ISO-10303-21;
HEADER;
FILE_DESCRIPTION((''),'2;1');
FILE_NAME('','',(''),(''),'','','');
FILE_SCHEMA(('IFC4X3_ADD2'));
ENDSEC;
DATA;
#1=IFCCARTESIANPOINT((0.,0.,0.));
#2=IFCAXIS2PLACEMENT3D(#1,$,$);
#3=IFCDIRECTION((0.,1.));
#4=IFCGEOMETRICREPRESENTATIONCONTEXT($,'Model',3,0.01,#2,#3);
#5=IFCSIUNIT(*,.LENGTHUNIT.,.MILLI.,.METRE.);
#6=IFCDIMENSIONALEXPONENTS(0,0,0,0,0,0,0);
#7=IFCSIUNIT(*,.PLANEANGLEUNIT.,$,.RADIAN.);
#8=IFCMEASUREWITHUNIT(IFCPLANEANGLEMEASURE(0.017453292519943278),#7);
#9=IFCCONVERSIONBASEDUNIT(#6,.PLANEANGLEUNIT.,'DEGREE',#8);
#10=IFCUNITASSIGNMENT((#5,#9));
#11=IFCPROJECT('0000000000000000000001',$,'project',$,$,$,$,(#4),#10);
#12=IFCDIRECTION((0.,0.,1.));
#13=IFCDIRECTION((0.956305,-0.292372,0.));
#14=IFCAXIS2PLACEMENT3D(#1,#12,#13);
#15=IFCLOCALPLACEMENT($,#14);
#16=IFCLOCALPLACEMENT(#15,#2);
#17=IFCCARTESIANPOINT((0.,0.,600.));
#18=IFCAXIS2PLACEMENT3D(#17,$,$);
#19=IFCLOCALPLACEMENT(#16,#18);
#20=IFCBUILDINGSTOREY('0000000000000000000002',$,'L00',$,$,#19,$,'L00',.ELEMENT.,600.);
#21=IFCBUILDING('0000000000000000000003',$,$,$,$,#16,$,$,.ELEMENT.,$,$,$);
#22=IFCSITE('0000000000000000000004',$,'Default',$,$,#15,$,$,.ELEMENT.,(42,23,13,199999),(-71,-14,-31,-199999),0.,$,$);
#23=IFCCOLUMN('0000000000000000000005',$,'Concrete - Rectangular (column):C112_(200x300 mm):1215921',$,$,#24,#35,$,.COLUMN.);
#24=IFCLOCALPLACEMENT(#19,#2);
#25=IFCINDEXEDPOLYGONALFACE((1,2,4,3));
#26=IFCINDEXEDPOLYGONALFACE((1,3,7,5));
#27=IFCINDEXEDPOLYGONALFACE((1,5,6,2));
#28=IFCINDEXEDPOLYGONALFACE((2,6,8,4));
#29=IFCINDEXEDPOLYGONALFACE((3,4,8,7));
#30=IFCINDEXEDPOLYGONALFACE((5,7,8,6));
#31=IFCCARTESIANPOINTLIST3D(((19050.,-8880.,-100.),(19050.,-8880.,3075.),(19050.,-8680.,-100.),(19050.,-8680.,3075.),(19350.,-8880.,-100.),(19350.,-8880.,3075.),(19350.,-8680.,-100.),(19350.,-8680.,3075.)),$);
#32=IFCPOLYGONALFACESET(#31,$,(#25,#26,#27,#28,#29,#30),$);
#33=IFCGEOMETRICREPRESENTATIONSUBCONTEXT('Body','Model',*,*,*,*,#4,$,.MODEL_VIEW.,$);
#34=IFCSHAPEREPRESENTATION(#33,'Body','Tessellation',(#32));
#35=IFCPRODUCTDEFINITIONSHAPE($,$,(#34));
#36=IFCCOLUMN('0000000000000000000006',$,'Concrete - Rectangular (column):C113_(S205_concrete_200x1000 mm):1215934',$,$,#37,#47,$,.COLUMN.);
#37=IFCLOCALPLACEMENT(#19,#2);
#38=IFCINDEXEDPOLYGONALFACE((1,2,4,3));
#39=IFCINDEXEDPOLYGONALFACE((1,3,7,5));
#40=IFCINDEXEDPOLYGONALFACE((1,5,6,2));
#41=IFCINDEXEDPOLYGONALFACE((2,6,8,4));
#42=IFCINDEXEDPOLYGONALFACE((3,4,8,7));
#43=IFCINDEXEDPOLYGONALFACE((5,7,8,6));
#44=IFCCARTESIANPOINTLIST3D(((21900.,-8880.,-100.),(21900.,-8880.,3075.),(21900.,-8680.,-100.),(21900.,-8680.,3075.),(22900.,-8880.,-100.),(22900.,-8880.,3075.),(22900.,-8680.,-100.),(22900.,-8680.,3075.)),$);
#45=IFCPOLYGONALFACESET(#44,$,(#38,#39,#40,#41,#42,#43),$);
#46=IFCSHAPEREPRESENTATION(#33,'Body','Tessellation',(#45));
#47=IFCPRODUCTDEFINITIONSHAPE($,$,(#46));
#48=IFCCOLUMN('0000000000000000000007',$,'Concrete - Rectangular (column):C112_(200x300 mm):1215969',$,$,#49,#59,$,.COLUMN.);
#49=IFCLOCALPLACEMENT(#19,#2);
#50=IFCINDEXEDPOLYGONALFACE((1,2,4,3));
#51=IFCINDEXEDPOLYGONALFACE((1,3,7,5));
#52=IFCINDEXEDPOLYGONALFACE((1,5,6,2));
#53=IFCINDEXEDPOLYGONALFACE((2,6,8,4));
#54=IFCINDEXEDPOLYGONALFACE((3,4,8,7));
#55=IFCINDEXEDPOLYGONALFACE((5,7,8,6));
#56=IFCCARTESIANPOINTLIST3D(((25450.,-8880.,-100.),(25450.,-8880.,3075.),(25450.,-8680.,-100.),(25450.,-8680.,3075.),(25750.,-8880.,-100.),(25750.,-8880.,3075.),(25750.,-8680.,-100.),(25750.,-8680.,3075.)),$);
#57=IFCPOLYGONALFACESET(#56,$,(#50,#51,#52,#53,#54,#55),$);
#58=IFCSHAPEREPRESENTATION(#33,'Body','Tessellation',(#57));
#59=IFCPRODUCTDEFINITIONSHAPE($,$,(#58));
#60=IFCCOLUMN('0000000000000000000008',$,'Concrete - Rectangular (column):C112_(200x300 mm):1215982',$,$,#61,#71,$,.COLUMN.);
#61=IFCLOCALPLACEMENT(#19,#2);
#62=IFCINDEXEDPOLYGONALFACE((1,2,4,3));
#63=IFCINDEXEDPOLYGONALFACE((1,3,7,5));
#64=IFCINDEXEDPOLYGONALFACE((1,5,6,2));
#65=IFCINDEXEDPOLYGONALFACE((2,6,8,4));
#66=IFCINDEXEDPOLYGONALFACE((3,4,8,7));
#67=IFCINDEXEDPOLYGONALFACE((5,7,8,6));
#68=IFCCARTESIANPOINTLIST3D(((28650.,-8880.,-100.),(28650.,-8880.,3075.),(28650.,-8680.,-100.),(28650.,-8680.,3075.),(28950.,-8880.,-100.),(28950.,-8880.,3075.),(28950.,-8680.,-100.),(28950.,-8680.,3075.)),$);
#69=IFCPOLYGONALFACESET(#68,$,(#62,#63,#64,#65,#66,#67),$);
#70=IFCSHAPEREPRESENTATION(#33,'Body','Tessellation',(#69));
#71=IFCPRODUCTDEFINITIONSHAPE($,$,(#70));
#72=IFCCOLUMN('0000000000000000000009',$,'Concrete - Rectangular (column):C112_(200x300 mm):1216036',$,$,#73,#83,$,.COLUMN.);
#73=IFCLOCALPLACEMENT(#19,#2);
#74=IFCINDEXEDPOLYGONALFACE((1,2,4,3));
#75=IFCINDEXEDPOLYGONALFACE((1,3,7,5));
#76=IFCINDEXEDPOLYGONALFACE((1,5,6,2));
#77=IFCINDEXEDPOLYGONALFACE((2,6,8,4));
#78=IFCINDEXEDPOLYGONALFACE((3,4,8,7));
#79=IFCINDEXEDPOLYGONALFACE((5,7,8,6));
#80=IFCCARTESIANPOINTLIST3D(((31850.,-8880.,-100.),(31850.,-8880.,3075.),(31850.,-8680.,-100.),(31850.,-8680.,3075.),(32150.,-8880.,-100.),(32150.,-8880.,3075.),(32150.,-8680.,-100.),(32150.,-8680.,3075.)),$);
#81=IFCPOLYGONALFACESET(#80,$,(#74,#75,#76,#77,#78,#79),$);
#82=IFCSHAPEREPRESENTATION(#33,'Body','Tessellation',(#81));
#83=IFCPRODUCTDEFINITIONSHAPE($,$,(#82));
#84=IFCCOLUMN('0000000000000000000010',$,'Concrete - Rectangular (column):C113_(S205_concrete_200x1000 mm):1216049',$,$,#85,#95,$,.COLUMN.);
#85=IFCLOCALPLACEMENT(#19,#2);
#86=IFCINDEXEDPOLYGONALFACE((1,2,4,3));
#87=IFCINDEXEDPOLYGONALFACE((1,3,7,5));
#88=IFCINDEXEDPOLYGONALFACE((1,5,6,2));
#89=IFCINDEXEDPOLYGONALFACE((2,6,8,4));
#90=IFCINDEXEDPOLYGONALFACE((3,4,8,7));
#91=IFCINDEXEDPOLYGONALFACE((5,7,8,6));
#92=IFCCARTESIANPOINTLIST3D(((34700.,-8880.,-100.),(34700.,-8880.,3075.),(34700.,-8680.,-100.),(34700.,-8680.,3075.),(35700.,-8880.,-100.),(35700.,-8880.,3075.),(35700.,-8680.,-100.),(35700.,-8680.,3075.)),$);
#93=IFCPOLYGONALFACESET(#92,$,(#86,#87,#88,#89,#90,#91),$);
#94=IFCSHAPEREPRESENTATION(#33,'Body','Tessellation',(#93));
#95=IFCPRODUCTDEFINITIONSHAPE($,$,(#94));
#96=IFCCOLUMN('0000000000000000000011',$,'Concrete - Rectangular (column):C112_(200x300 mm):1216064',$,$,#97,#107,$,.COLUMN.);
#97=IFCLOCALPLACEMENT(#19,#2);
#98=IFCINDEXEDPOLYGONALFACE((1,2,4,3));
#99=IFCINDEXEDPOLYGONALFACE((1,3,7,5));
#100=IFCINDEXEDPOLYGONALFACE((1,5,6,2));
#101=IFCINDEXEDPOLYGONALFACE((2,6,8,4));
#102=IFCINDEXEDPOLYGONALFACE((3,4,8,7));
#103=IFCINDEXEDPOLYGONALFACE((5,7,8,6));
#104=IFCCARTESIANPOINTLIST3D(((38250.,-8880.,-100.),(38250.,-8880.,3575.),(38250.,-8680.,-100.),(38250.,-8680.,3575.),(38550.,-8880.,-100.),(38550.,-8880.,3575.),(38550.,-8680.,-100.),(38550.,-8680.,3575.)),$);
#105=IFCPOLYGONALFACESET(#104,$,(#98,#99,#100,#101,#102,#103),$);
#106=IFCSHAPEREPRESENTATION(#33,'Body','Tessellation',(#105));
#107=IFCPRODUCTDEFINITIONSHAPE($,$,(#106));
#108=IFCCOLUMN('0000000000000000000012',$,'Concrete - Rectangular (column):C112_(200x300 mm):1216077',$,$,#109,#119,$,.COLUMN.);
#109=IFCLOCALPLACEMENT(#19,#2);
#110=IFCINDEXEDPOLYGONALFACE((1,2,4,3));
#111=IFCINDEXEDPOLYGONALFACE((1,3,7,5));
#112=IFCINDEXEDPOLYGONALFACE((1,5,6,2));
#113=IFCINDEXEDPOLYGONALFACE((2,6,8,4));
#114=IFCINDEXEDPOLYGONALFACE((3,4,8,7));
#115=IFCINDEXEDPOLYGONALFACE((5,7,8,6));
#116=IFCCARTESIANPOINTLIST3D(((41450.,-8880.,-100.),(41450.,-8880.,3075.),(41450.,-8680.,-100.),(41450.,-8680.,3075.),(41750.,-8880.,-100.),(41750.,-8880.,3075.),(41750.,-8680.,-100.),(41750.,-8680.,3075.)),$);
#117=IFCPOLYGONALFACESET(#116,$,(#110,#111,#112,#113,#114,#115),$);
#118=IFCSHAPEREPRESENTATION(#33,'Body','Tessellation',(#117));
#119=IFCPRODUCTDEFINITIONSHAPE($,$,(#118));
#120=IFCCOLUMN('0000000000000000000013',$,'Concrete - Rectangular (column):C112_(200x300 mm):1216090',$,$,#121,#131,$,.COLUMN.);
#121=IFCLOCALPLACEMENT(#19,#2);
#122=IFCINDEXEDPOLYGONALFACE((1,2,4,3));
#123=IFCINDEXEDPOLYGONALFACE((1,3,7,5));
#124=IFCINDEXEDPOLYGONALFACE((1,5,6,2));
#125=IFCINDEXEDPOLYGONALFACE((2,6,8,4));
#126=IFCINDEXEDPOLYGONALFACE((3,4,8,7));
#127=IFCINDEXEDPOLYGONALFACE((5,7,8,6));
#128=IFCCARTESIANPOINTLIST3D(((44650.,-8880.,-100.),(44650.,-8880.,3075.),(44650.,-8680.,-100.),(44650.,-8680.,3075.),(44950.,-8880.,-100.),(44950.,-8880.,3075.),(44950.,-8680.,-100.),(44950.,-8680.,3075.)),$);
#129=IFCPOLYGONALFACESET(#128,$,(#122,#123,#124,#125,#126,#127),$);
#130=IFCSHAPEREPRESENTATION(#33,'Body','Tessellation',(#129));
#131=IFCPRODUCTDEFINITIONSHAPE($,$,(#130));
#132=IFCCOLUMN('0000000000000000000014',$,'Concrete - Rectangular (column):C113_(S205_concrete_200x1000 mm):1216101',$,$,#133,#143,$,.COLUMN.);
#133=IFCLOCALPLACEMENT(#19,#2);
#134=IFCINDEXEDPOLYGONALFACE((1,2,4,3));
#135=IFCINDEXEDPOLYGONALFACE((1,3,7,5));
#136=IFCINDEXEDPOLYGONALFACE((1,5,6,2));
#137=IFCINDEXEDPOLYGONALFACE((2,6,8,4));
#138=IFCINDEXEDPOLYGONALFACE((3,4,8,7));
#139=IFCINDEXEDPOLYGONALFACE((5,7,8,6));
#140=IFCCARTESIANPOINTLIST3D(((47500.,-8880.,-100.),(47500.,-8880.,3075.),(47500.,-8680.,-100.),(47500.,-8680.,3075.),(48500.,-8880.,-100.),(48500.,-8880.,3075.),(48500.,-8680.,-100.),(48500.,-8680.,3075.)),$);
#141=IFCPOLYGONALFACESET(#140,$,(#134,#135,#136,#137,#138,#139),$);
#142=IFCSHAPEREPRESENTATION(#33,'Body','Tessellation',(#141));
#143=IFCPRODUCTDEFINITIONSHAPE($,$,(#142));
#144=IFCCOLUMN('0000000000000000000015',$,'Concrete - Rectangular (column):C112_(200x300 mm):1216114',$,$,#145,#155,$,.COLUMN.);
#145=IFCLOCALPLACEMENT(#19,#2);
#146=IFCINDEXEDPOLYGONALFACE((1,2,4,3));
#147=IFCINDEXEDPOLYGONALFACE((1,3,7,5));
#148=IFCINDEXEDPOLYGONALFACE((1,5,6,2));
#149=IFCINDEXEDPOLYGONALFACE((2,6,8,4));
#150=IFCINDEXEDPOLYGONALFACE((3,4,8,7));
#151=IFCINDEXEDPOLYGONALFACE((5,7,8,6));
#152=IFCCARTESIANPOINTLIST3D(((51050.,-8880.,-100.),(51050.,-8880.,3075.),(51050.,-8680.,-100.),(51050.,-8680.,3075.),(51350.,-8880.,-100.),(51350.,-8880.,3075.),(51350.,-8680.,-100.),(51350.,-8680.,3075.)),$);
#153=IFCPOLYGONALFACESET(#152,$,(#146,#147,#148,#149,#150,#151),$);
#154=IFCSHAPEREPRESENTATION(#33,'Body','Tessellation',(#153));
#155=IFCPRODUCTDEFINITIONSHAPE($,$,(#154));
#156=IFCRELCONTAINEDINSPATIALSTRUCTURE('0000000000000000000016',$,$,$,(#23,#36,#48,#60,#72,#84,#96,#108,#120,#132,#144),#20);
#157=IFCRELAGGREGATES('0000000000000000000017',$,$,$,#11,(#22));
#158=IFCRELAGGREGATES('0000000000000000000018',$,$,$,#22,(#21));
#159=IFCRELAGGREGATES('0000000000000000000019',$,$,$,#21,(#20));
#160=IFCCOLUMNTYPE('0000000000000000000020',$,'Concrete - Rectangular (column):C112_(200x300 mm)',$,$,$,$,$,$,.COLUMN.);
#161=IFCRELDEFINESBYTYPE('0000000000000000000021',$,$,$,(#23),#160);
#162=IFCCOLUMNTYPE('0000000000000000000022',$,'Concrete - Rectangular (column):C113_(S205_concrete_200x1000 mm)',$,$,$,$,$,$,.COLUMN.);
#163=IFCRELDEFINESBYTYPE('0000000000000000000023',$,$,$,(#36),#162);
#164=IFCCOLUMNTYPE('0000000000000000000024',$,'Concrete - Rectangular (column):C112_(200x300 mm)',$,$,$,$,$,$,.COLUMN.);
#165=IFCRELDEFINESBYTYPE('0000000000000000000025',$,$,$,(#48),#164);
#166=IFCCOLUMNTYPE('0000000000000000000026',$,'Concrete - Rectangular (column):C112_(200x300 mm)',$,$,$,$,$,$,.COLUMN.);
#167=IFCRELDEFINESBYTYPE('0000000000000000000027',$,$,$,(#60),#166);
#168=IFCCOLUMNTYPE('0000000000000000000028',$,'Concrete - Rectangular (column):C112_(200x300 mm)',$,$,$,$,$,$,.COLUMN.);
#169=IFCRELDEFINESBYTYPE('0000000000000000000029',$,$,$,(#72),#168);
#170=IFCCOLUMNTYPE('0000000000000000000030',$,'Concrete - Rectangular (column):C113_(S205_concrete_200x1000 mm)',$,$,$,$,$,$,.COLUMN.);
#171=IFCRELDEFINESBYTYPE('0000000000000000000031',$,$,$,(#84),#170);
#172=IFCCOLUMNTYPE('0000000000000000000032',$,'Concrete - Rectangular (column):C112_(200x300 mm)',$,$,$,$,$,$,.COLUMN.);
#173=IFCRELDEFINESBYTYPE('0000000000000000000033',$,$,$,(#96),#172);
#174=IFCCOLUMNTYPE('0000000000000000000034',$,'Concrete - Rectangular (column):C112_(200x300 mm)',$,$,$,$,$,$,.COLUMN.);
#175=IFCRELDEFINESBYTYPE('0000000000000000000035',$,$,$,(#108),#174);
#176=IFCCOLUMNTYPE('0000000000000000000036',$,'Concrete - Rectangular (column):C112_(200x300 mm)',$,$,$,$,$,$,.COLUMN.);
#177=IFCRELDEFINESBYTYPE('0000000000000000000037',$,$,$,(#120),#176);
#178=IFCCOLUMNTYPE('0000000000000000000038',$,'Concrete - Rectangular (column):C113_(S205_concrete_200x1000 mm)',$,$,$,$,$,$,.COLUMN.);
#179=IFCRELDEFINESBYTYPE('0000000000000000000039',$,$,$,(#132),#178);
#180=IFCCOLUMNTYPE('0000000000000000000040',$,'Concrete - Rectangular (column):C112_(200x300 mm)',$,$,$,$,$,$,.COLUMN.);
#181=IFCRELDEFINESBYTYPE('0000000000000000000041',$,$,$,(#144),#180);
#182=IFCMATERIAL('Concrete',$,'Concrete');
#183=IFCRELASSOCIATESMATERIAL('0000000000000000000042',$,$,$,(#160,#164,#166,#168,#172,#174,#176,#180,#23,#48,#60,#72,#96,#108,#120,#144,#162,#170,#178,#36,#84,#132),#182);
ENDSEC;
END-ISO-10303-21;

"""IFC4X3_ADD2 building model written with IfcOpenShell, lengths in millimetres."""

from ifc_helpers import new_model, entity, si_unit, converted_unit, direction, frame, frame_2d, origin, place, context, subcontext, project, spatial, rectangle, extrude, source, transform, mapped, material, material_profile, profile_set, profile_usage, type_object, type_shapes, element, save


model = new_model("IFC4X3_ADD2")

# Units and contexts
model_context = context("Model", 3, precision=0.01, world=origin(), true_north=direction((0.0, 1.0)))
body_context = subcontext(model_context, "Body", "Model", "MODEL_VIEW")
ifc_project = project(units=[si_unit("LENGTHUNIT", "METRE", prefix="MILLI"), converted_unit("PLANEANGLEUNIT", "DEGREE", entity("IfcPlaneAngleMeasure", 0.017453292519943278), si_unit("PLANEANGLEUNIT", "RADIAN"), dimensions=[0, 0, 0, 0, 0, 0, 0])], contexts=[model_context])

# Site, building, storey
site_placement = place(None, frame((0.0, 0.0, 0.0), z_axis=(0.0, 0.0, 1.0), x_axis=(0.956305, -0.292372, 0.0)))
site = spatial("IfcSite", under=ifc_project, at=site_placement, Name="Default", CompositionType="ELEMENT", RefLatitude=(42, 23, 13, 199999), RefLongitude=(-71, -14, -31, -199999), RefElevation=0.0)
building_placement = place(site_placement, origin())
building = spatial("IfcBuilding", under=site, at=building_placement, CompositionType="ELEMENT")
storey_placement = place(building_placement, frame((0.0, 0.0, 600.0)))
storey = spatial("IfcBuildingStorey", under=building, at=storey_placement, Name="L00", LongName="L00", CompositionType="ELEMENT", Elevation=600.0)

# Columns
ifc_material = material(Name="Concrete", Category="Concrete")
ifc_material_profile_1 = material_profile(ifc_material, rectangle(XDim=200.0, YDim=300.0, at=frame_2d((0.0, 0.0), x_axis=(1.0, 0.0))), Name="C112_(200x300 mm)")
ifc_profile_set_1 = profile_set([ifc_material_profile_1], Name="C112_(200x300 mm)")
ifc_profile_usage_1 = profile_usage(ifc_profile_set_1)
column_type_1 = type_object("IfcColumnType", Name="Concrete - Rectangular (column):C112_(200x300 mm)", PredefinedType="COLUMN", material=ifc_profile_set_1)
shared_shape_1 = source(origin(), body_context, "Body", "SweptSolid", [
    extrude(rectangle(XDim=200.0, YDim=300.0, at=frame_2d((0.0, 0.0), x_axis=(1.0, 0.0))), frame((19200.0, -8780.0, 500.0), z_axis=(0.0, 0.0, 1.0), x_axis=(0.0, 1.0, 0.0)), (0.0, 0.0, 1.0), 3175.0),
])
type_shapes(column_type_1, [shared_shape_1])
column_1_placement = place(storey_placement, frame((0.0, 0.0, -600.0)))
element("IfcColumn", 1, at=column_1_placement, inside=storey, type_object=column_type_1, material=ifc_profile_usage_1, Name="Concrete - Rectangular (column):C112_(200x300 mm):1215921", PredefinedType="COLUMN", context=body_context, shape_type="MappedRepresentation", body=[
    mapped(shared_shape_1, transform((0.0, 0.0, 0.0), scale=1.0)),
])
ifc_material_profile_2 = material_profile(ifc_material, rectangle(XDim=200.0, YDim=1000.0, at=frame_2d((0.0, 0.0), x_axis=(1.0, 0.0))), Name="C113_(S205_concrete_200x1000 mm)")
ifc_profile_set_2 = profile_set([ifc_material_profile_2], Name="C113_(S205_concrete_200x1000 mm)")
ifc_profile_usage_2 = profile_usage(ifc_profile_set_2)
column_type_2 = type_object("IfcColumnType", Name="Concrete - Rectangular (column):C113_(S205_concrete_200x1000 mm)", PredefinedType="COLUMN", material=ifc_profile_set_2)
shared_shape_2 = source(origin(), body_context, "Body", "SweptSolid", [
    extrude(rectangle(XDim=200.0, YDim=1000.0, at=frame_2d((0.0, 0.0), x_axis=(1.0, 0.0))), frame((22400.0, -8780.0, 500.0), z_axis=(0.0, 0.0, 1.0), x_axis=(0.0, 1.0, 0.0)), (0.0, 0.0, 1.0), 3175.0),
])
type_shapes(column_type_2, [shared_shape_2])
column_2_placement = place(storey_placement, frame((0.0, 0.0, -600.0)))
element("IfcColumn", 2, at=column_2_placement, inside=storey, type_object=column_type_2, material=ifc_profile_usage_2, Name="Concrete - Rectangular (column):C113_(S205_concrete_200x1000 mm):1215934", PredefinedType="COLUMN", context=body_context, shape_type="MappedRepresentation", body=[
    mapped(shared_shape_2, transform((0.0, 0.0, 0.0), scale=1.0)),
])
column_type_3 = type_object("IfcColumnType", Name="Concrete - Rectangular (column):C112_(200x300 mm)", PredefinedType="COLUMN", material=ifc_profile_set_1)
shared_shape_3 = source(origin(), body_context, "Body", "SweptSolid", [
    extrude(rectangle(XDim=200.0, YDim=300.0, at=frame_2d((0.0, 0.0), x_axis=(1.0, 0.0))), frame((25600.0, -8780.0, 500.0), z_axis=(0.0, 0.0, 1.0), x_axis=(0.0, 1.0, 0.0)), (0.0, 0.0, 1.0), 3175.0),
])
type_shapes(column_type_3, [shared_shape_3])
column_3_placement = place(storey_placement, frame((0.0, 0.0, -600.0)))
element("IfcColumn", 3, at=column_3_placement, inside=storey, type_object=column_type_3, material=ifc_profile_usage_1, Name="Concrete - Rectangular (column):C112_(200x300 mm):1215969", PredefinedType="COLUMN", context=body_context, shape_type="MappedRepresentation", body=[
    mapped(shared_shape_3, transform((0.0, 0.0, 0.0), scale=1.0)),
])
column_type_4 = type_object("IfcColumnType", Name="Concrete - Rectangular (column):C112_(200x300 mm)", PredefinedType="COLUMN", material=ifc_profile_set_1)
shared_shape_4 = source(origin(), body_context, "Body", "SweptSolid", [
    extrude(rectangle(XDim=200.0, YDim=300.0, at=frame_2d((0.0, 0.0), x_axis=(1.0, 0.0))), frame((28800.0, -8780.0, 500.0), z_axis=(0.0, 0.0, 1.0), x_axis=(0.0, 1.0, 0.0)), (0.0, 0.0, 1.0), 3175.0),
])
type_shapes(column_type_4, [shared_shape_4])
column_4_placement = place(storey_placement, frame((0.0, 0.0, -600.0)))
element("IfcColumn", 4, at=column_4_placement, inside=storey, type_object=column_type_4, material=ifc_profile_usage_1, Name="Concrete - Rectangular (column):C112_(200x300 mm):1215982", PredefinedType="COLUMN", context=body_context, shape_type="MappedRepresentation", body=[
    mapped(shared_shape_4, transform((0.0, 0.0, 0.0), scale=1.0)),
])
column_type_5 = type_object("IfcColumnType", Name="Concrete - Rectangular (column):C112_(200x300 mm)", PredefinedType="COLUMN", material=ifc_profile_set_1)
shared_shape_5 = source(origin(), body_context, "Body", "SweptSolid", [
    extrude(rectangle(XDim=200.0, YDim=300.0, at=frame_2d((0.0, 0.0), x_axis=(1.0, 0.0))), frame((32000.0, -8780.0, 500.0), z_axis=(0.0, 0.0, 1.0), x_axis=(0.0, 1.0, 0.0)), (0.0, 0.0, 1.0), 3175.0),
])
type_shapes(column_type_5, [shared_shape_5])
column_5_placement = place(storey_placement, frame((0.0, 0.0, -600.0)))
element("IfcColumn", 5, at=column_5_placement, inside=storey, type_object=column_type_5, material=ifc_profile_usage_1, Name="Concrete - Rectangular (column):C112_(200x300 mm):1216036", PredefinedType="COLUMN", context=body_context, shape_type="MappedRepresentation", body=[
    mapped(shared_shape_5, transform((0.0, 0.0, 0.0), scale=1.0)),
])
column_type_6 = type_object("IfcColumnType", Name="Concrete - Rectangular (column):C113_(S205_concrete_200x1000 mm)", PredefinedType="COLUMN", material=ifc_profile_set_2)
shared_shape_6 = source(origin(), body_context, "Body", "SweptSolid", [
    extrude(rectangle(XDim=200.0, YDim=1000.0, at=frame_2d((0.0, 0.0), x_axis=(1.0, 0.0))), frame((35200.0, -8780.0, 500.0), z_axis=(0.0, 0.0, 1.0), x_axis=(0.0, 1.0, 0.0)), (0.0, 0.0, 1.0), 3175.0),
])
type_shapes(column_type_6, [shared_shape_6])
column_6_placement = place(storey_placement, frame((0.0, 0.0, -600.0)))
element("IfcColumn", 6, at=column_6_placement, inside=storey, type_object=column_type_6, material=ifc_profile_usage_2, Name="Concrete - Rectangular (column):C113_(S205_concrete_200x1000 mm):1216049", PredefinedType="COLUMN", context=body_context, shape_type="MappedRepresentation", body=[
    mapped(shared_shape_6, transform((0.0, 0.0, 0.0), scale=1.0)),
])
column_type_7 = type_object("IfcColumnType", Name="Concrete - Rectangular (column):C112_(200x300 mm)", PredefinedType="COLUMN", material=ifc_profile_set_1)
shared_shape_7 = source(origin(), body_context, "Body", "SweptSolid", [
    extrude(rectangle(XDim=200.0, YDim=300.0, at=frame_2d((0.0, 0.0), x_axis=(1.0, 0.0))), frame((38400.0, -8780.0, 500.0), z_axis=(0.0, 0.0, 1.0), x_axis=(0.0, 1.0, 0.0)), (0.0, 0.0, 1.0), 3675.0),
])
type_shapes(column_type_7, [shared_shape_7])
column_7_placement = place(storey_placement, frame((0.0, 0.0, -600.0)))
element("IfcColumn", 7, at=column_7_placement, inside=storey, type_object=column_type_7, material=ifc_profile_usage_1, Name="Concrete - Rectangular (column):C112_(200x300 mm):1216064", PredefinedType="COLUMN", context=body_context, shape_type="MappedRepresentation", body=[
    mapped(shared_shape_7, transform((0.0, 0.0, 0.0), scale=1.0)),
])
column_type_8 = type_object("IfcColumnType", Name="Concrete - Rectangular (column):C112_(200x300 mm)", PredefinedType="COLUMN", material=ifc_profile_set_1)
shared_shape_8 = source(origin(), body_context, "Body", "SweptSolid", [
    extrude(rectangle(XDim=200.0, YDim=300.0, at=frame_2d((0.0, 0.0), x_axis=(1.0, 0.0))), frame((41600.0, -8780.0, 500.0), z_axis=(0.0, 0.0, 1.0), x_axis=(0.0, 1.0, 0.0)), (0.0, 0.0, 1.0), 3175.0),
])
type_shapes(column_type_8, [shared_shape_8])
column_8_placement = place(storey_placement, frame((0.0, 0.0, -600.0)))
element("IfcColumn", 8, at=column_8_placement, inside=storey, type_object=column_type_8, material=ifc_profile_usage_1, Name="Concrete - Rectangular (column):C112_(200x300 mm):1216077", PredefinedType="COLUMN", context=body_context, shape_type="MappedRepresentation", body=[
    mapped(shared_shape_8, transform((0.0, 0.0, 0.0), scale=1.0)),
])
column_type_9 = type_object("IfcColumnType", Name="Concrete - Rectangular (column):C112_(200x300 mm)", PredefinedType="COLUMN", material=ifc_profile_set_1)
shared_shape_9 = source(origin(), body_context, "Body", "SweptSolid", [
    extrude(rectangle(XDim=200.0, YDim=300.0, at=frame_2d((0.0, 0.0), x_axis=(1.0, 0.0))), frame((44800.0, -8780.0, 500.0), z_axis=(0.0, 0.0, 1.0), x_axis=(0.0, 1.0, 0.0)), (0.0, 0.0, 1.0), 3175.0),
])
type_shapes(column_type_9, [shared_shape_9])
column_9_placement = place(storey_placement, frame((0.0, 0.0, -600.0)))
element("IfcColumn", 9, at=column_9_placement, inside=storey, type_object=column_type_9, material=ifc_profile_usage_1, Name="Concrete - Rectangular (column):C112_(200x300 mm):1216090", PredefinedType="COLUMN", context=body_context, shape_type="MappedRepresentation", body=[
    mapped(shared_shape_9, transform((0.0, 0.0, 0.0), scale=1.0)),
])
column_type_10 = type_object("IfcColumnType", Name="Concrete - Rectangular (column):C113_(S205_concrete_200x1000 mm)", PredefinedType="COLUMN", material=ifc_profile_set_2)
shared_shape_10 = source(origin(), body_context, "Body", "SweptSolid", [
    extrude(rectangle(XDim=200.0, YDim=1000.0, at=frame_2d((0.0, 0.0), x_axis=(1.0, 0.0))), frame((48000.0, -8780.0, 500.0), z_axis=(0.0, 0.0, 1.0), x_axis=(0.0, 1.0, 0.0)), (0.0, 0.0, 1.0), 3175.0),
])
type_shapes(column_type_10, [shared_shape_10])
column_10_placement = place(storey_placement, frame((0.0, 0.0, -600.0)))
element("IfcColumn", 10, at=column_10_placement, inside=storey, type_object=column_type_10, material=ifc_profile_usage_2, Name="Concrete - Rectangular (column):C113_(S205_concrete_200x1000 mm):1216101", PredefinedType="COLUMN", context=body_context, shape_type="MappedRepresentation", body=[
    mapped(shared_shape_10, transform((0.0, 0.0, 0.0), scale=1.0)),
])
column_type_11 = type_object("IfcColumnType", Name="Concrete - Rectangular (column):C112_(200x300 mm)", PredefinedType="COLUMN", material=ifc_profile_set_1)
shared_shape_11 = source(origin(), body_context, "Body", "SweptSolid", [
    extrude(rectangle(XDim=200.0, YDim=300.0, at=frame_2d((0.0, 0.0), x_axis=(1.0, 0.0))), frame((51200.0, -8780.0, 500.0), z_axis=(0.0, 0.0, 1.0), x_axis=(0.0, 1.0, 0.0)), (0.0, 0.0, 1.0), 3175.0),
])
type_shapes(column_type_11, [shared_shape_11])
column_11_placement = place(storey_placement, frame((0.0, 0.0, -600.0)))
element("IfcColumn", 11, at=column_11_placement, inside=storey, type_object=column_type_11, material=ifc_profile_usage_1, Name="Concrete - Rectangular (column):C112_(200x300 mm):1216114", PredefinedType="COLUMN", context=body_context, shape_type="MappedRepresentation", body=[
    mapped(shared_shape_11, transform((0.0, 0.0, 0.0), scale=1.0)),
])

save(model, "model.ifc")
